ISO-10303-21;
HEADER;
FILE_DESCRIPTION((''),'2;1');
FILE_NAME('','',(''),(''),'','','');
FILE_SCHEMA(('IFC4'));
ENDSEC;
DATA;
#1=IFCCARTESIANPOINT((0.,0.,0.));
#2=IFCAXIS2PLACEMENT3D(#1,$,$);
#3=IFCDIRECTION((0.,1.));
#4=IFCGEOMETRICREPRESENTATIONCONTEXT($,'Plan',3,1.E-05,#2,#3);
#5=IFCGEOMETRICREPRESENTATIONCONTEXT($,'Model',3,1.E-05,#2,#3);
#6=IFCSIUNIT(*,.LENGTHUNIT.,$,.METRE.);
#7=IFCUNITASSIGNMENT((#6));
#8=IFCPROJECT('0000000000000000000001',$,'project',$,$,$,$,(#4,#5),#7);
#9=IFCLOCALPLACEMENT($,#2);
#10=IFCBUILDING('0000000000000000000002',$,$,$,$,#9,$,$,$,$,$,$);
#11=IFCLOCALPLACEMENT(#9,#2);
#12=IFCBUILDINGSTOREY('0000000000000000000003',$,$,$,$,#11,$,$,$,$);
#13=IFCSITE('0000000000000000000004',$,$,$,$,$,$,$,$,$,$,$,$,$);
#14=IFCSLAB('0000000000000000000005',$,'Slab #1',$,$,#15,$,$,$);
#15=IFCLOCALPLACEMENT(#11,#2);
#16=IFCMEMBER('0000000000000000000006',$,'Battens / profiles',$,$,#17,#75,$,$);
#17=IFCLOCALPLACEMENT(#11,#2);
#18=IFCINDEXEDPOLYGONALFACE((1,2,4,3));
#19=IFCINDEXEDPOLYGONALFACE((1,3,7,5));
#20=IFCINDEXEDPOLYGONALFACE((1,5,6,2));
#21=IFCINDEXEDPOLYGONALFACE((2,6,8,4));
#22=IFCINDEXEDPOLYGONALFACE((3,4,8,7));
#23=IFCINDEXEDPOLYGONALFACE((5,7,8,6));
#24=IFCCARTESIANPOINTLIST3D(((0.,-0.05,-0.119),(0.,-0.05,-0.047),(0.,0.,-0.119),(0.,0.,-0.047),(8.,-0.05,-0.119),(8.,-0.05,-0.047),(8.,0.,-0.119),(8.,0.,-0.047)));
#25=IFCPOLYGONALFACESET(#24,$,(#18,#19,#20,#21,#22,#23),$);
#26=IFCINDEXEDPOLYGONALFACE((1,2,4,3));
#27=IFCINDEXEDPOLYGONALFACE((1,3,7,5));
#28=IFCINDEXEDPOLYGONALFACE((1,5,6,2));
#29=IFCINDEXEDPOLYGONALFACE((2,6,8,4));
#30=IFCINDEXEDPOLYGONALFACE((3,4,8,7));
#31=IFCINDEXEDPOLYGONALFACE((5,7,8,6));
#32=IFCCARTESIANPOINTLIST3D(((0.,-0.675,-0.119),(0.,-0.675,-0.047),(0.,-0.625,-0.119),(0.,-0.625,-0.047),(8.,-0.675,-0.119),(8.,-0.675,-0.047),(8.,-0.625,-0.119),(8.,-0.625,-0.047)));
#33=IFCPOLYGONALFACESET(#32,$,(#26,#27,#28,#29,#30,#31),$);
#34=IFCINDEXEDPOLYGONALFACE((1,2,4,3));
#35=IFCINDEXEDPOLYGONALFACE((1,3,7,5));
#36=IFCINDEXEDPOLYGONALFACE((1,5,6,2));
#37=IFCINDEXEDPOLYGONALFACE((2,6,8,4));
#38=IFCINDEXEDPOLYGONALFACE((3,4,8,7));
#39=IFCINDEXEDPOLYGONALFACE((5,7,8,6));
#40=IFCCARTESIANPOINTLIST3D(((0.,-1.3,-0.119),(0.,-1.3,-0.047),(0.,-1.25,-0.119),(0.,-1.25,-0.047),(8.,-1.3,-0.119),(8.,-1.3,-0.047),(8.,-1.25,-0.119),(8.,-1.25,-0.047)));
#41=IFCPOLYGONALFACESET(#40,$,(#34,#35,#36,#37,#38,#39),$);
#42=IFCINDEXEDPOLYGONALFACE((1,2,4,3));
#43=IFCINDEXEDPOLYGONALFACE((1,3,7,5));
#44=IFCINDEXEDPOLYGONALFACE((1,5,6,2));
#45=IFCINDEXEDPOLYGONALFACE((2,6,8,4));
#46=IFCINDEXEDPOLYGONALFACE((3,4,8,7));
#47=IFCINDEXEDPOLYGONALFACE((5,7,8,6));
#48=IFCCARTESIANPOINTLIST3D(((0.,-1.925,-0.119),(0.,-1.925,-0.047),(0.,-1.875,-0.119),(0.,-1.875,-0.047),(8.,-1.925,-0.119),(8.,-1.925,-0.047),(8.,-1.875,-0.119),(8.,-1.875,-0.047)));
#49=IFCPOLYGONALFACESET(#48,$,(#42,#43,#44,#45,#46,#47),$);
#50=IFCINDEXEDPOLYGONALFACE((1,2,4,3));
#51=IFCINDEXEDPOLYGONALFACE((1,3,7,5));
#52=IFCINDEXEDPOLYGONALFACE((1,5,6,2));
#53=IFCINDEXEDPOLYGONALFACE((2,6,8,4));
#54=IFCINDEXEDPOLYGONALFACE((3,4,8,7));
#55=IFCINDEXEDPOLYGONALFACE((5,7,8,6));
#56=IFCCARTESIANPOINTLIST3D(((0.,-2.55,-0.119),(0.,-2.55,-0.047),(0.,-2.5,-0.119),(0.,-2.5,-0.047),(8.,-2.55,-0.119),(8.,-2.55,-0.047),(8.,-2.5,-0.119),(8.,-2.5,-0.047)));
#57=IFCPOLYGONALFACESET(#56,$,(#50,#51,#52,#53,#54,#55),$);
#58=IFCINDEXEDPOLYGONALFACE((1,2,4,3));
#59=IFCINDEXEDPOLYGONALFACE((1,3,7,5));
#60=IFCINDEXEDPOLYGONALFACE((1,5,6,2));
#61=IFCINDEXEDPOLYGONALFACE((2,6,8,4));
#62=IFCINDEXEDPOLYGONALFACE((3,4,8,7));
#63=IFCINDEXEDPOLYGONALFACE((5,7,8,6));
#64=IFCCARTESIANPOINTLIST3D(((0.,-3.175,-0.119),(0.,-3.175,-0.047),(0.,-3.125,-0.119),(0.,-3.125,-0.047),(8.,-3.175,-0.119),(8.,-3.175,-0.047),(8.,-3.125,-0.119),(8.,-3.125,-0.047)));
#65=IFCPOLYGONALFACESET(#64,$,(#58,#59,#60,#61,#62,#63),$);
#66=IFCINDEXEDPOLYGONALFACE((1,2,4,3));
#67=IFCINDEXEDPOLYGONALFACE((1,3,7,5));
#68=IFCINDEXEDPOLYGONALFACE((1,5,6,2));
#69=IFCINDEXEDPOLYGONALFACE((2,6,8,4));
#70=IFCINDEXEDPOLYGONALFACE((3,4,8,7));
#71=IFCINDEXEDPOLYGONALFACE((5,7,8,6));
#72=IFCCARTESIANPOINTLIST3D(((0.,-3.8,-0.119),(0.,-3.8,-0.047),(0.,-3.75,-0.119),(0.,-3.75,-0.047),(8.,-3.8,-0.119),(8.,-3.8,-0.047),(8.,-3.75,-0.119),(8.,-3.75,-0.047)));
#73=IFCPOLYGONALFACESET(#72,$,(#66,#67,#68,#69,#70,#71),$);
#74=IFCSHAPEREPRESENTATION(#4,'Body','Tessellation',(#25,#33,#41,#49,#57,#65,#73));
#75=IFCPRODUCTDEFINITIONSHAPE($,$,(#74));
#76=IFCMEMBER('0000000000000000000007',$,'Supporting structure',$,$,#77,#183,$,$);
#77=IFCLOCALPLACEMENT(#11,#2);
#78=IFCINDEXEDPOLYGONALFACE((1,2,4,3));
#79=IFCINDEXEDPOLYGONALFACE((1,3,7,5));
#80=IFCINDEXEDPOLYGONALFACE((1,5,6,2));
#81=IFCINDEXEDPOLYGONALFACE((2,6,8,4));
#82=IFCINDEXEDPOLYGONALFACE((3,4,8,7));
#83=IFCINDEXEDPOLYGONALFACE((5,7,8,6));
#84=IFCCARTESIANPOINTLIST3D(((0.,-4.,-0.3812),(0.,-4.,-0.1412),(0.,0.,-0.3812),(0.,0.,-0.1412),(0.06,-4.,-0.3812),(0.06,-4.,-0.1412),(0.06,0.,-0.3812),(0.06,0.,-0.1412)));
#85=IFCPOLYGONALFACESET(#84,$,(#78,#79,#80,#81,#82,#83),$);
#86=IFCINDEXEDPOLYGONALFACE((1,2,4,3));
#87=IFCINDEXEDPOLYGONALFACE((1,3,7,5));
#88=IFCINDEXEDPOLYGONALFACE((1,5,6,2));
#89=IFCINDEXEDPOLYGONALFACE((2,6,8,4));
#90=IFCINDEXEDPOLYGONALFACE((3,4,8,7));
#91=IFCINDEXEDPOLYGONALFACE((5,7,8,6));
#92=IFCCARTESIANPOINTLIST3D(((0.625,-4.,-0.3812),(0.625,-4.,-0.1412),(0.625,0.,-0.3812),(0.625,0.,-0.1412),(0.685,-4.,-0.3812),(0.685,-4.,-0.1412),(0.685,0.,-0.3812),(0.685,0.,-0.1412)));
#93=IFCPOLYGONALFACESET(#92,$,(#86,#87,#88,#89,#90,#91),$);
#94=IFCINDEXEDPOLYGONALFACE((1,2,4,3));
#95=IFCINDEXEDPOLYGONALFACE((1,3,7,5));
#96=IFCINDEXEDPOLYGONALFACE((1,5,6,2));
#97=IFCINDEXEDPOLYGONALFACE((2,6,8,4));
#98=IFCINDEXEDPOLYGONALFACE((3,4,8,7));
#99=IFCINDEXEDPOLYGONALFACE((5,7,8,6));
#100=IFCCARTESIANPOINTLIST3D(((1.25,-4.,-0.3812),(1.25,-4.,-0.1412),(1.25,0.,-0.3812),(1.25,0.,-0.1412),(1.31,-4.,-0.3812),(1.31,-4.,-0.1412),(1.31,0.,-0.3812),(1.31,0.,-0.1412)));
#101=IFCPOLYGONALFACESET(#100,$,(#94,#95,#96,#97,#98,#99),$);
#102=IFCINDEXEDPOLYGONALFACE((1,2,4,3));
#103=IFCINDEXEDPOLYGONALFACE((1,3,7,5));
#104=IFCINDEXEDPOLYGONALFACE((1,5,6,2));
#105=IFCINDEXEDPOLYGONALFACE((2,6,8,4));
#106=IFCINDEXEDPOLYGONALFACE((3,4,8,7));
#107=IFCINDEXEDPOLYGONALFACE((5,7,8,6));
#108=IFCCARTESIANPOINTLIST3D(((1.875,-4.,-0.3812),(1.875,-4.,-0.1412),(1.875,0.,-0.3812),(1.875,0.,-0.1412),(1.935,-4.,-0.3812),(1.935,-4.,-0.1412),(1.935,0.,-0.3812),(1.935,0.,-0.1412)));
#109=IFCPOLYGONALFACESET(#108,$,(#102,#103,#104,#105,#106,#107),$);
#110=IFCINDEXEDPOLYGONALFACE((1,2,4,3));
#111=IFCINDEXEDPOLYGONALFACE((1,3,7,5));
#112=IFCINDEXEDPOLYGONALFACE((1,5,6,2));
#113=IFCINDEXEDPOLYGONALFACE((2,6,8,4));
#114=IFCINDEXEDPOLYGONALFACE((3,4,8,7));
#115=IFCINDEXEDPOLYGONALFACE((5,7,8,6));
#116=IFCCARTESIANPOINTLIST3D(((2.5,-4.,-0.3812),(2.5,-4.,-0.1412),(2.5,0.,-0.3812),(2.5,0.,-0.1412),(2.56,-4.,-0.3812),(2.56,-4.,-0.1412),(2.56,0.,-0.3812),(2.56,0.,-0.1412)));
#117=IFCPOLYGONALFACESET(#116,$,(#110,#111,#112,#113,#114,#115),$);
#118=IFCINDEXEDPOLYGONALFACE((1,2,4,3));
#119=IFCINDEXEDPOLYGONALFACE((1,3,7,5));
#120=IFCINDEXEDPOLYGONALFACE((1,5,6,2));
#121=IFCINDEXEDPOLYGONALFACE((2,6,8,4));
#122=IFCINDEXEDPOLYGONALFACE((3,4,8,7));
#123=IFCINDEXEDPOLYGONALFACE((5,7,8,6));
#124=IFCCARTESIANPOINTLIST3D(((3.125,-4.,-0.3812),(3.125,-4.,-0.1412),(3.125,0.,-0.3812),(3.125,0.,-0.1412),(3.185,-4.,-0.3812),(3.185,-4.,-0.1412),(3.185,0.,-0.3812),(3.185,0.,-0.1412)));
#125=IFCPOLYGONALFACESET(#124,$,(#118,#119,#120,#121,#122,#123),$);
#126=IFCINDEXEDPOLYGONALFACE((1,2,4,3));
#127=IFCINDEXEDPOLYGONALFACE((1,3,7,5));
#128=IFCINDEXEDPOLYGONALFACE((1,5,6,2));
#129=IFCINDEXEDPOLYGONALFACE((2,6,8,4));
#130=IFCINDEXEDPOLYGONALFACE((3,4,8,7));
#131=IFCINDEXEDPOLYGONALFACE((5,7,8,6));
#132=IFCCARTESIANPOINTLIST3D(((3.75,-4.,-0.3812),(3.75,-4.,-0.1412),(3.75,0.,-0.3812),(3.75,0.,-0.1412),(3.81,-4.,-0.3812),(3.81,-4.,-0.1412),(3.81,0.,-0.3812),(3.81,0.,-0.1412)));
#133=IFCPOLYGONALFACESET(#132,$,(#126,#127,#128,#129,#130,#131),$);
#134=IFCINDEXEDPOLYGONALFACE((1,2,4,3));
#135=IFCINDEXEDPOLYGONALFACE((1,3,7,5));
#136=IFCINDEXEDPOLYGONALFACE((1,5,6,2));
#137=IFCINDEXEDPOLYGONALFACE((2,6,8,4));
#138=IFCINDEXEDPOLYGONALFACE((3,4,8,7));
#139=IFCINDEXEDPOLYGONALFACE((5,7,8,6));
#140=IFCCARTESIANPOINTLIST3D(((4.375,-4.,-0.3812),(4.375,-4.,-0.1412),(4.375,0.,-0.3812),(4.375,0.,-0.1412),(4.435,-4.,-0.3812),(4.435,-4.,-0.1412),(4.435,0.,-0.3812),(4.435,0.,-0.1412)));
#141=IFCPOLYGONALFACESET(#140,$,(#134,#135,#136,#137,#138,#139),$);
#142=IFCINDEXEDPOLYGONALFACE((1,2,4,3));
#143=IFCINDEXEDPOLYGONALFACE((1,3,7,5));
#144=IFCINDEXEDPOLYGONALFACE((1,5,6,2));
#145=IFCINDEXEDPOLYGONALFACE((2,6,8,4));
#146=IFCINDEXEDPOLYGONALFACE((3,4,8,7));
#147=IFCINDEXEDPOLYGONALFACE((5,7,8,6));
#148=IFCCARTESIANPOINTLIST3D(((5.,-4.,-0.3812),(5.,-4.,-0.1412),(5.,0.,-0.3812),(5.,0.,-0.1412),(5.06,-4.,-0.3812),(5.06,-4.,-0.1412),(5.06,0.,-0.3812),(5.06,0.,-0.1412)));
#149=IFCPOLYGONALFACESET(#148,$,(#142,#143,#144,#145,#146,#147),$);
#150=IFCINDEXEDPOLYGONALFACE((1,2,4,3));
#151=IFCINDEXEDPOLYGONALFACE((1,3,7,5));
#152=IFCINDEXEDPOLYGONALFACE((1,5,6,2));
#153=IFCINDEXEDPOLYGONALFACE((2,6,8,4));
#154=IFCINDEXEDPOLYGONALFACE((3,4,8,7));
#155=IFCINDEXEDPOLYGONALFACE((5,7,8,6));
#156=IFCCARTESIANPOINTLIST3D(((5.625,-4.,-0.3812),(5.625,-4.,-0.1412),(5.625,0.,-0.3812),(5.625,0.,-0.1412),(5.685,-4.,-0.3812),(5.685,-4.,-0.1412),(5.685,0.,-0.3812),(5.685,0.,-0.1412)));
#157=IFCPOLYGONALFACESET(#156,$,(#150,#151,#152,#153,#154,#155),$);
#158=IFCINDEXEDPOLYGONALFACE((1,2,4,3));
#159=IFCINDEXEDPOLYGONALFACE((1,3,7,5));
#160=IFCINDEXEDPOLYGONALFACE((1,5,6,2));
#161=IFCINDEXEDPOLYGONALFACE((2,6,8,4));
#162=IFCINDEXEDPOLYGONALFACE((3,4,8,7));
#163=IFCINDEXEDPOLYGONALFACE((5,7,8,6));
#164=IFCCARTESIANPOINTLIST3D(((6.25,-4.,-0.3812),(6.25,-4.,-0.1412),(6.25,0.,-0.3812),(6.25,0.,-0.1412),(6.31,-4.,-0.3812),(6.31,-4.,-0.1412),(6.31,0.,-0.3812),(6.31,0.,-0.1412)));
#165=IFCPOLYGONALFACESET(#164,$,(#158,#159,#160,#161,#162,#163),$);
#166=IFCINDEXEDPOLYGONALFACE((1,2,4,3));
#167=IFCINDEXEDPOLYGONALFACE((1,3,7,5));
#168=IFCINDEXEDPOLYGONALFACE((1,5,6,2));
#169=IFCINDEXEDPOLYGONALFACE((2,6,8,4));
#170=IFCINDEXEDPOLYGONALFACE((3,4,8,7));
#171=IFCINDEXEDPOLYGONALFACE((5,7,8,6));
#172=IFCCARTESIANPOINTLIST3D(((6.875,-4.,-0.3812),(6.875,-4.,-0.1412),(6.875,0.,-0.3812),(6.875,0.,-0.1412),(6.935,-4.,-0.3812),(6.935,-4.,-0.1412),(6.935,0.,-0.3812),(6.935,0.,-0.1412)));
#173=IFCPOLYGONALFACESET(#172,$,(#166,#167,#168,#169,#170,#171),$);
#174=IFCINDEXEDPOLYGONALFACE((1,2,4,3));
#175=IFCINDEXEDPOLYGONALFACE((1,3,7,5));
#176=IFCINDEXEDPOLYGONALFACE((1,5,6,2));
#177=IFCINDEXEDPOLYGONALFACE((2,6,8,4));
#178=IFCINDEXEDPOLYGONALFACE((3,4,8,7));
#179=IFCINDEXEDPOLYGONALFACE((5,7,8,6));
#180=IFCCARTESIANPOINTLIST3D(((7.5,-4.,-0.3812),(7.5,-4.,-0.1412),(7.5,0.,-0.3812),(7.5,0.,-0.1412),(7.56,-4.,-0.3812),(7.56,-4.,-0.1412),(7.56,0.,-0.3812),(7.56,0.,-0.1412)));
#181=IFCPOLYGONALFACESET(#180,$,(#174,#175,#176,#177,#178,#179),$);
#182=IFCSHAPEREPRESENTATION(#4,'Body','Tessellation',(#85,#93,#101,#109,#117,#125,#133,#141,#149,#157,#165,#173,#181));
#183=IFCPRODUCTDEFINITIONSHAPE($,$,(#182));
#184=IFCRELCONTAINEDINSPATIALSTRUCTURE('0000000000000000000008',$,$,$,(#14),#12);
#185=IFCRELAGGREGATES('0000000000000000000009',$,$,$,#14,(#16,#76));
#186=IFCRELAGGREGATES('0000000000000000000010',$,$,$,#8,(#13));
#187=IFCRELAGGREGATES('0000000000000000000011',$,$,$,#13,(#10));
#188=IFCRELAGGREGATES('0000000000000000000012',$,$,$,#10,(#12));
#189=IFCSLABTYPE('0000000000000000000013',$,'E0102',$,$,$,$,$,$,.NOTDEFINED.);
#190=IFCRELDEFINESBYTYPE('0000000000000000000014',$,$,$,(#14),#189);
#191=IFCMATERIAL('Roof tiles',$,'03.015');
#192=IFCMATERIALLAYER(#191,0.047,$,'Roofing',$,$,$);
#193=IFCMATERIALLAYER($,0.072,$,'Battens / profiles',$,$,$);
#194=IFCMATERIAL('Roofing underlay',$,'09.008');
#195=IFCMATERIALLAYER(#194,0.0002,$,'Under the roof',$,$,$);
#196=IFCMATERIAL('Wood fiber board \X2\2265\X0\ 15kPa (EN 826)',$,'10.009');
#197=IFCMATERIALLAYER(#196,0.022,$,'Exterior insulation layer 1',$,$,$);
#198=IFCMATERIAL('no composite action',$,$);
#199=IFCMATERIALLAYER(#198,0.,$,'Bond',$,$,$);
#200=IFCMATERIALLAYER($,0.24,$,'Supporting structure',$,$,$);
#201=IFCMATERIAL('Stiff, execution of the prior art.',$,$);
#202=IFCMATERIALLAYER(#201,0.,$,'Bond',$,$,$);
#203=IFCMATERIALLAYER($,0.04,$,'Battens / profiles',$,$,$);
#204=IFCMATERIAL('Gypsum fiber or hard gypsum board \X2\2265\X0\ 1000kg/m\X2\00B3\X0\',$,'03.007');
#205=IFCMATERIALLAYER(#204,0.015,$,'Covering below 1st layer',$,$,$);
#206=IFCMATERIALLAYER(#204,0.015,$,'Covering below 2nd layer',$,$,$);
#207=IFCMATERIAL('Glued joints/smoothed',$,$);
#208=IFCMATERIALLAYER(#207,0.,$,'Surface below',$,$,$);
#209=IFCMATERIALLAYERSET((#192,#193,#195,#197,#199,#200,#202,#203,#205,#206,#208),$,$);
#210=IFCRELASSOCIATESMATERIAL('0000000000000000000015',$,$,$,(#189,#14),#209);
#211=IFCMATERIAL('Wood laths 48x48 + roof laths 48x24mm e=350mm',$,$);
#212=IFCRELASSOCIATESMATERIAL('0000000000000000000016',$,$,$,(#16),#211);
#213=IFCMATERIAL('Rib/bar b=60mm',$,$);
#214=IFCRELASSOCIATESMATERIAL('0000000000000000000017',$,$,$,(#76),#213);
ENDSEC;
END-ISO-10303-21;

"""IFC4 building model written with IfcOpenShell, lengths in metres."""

from ifc_helpers import new_model, si_unit, direction, frame, frame_2d, origin, place, context, project, spatial, rectangle, extrude, material, layer, layer_set, type_object, element, aggregate, save


model = new_model("IFC4")

# Units and contexts
plan_context = context("Plan", 3, precision=1e-05, world=origin(), true_north=direction((0.0, 1.0)))
model_context = context("Model", 3, precision=1e-05, world=origin(), true_north=direction((0.0, 1.0)))
ifc_project = project(units=[si_unit("LENGTHUNIT", "METRE")], contexts=[plan_context, model_context])

# Site, building, storey
site = spatial("IfcSite", under=ifc_project)
building_placement = place(None, origin())
building = spatial("IfcBuilding", under=site, at=building_placement)
storey_placement = place(building_placement, origin())
storey = spatial("IfcBuildingStorey", under=building, at=storey_placement)

# Slab, members
ifc_material_1 = material(Name="Roof tiles", Category="03.015")
ifc_layer_1 = layer(ifc_material_1, 0.047, Name="Roofing")
ifc_layer_2 = layer(None, 0.072, Name="Battens / profiles")
ifc_material_2 = material(Name="Roofing underlay", Category="09.008")
ifc_layer_3 = layer(ifc_material_2, 0.0002, Name="Under the roof")
ifc_material_3 = material(Name="Wood fiber board ≥ 15kPa (EN 826)", Category="10.009")
ifc_layer_4 = layer(ifc_material_3, 0.022, Name="Exterior insulation layer 1")
ifc_material_4 = material(Name="no composite action")
ifc_layer_5 = layer(ifc_material_4, 0.0, Name="Bond")
ifc_layer_6 = layer(None, 0.24, Name="Supporting structure")
ifc_material_5 = material(Name="Stiff, execution of the prior art.")
ifc_layer_7 = layer(ifc_material_5, 0.0, Name="Bond")
ifc_layer_8 = layer(None, 0.04, Name="Battens / profiles")
ifc_material_6 = material(Name="Gypsum fiber or hard gypsum board ≥ 1000kg/m³", Category="03.007")
ifc_layer_9 = layer(ifc_material_6, 0.015, Name="Covering below 1st layer")
ifc_layer_10 = layer(ifc_material_6, 0.015, Name="Covering below 2nd layer")
ifc_material_7 = material(Name="Glued joints/smoothed")
ifc_layer_11 = layer(ifc_material_7, 0.0, Name="Surface below")
ifc_layer_set = layer_set([ifc_layer_1, ifc_layer_2, ifc_layer_3, ifc_layer_4, ifc_layer_5, ifc_layer_6, ifc_layer_7, ifc_layer_8, ifc_layer_9, ifc_layer_10, ifc_layer_11])
slab_type = type_object("IfcSlabType", Name="E0102", PredefinedType="NOTDEFINED", material=ifc_layer_set)
slab_placement = place(None, frame((0.0, 0.0, 0.0), z_axis=(0.0, 0.0, -1.0), x_axis=(1.0, 0.0, 0.0)))
slab = element("IfcSlab", 1, at=slab_placement, inside=storey, type_object=slab_type, material=ifc_layer_set, Name="Slab #1")
ifc_material_8 = material(Name="Wood laths 48x48 + roof laths 48x24mm e=350mm")
member_1_placement = place(slab_placement, origin())
member_1 = element("IfcMember", 2, at=member_1_placement, material=ifc_material_8, Name="Battens / profiles", context=plan_context, shape_type="SweptSolid", body=[
    extrude(rectangle(XDim=0.05, YDim=0.072, at=frame_2d((0.025, 0.036), x_axis=(1.0, 0.0))), frame((0.0, 0.0, 0.047), z_axis=(1.0, 0.0, 0.0), x_axis=(0.0, 1.0, 0.0)), (0.0, 0.0, 1.0), 8.0),
    extrude(rectangle(XDim=0.05, YDim=0.072, at=frame_2d((0.025, 0.036), x_axis=(1.0, 0.0))), frame((0.0, 0.625, 0.047), z_axis=(1.0, 0.0, 0.0), x_axis=(0.0, 1.0, 0.0)), (0.0, 0.0, 1.0), 8.0),
    extrude(rectangle(XDim=0.05, YDim=0.072, at=frame_2d((0.025, 0.036), x_axis=(1.0, 0.0))), frame((0.0, 1.25, 0.047), z_axis=(1.0, 0.0, 0.0), x_axis=(0.0, 1.0, 0.0)), (0.0, 0.0, 1.0), 8.0),
    extrude(rectangle(XDim=0.05, YDim=0.072, at=frame_2d((0.025, 0.036), x_axis=(1.0, 0.0))), frame((0.0, 1.875, 0.047), z_axis=(1.0, 0.0, 0.0), x_axis=(0.0, 1.0, 0.0)), (0.0, 0.0, 1.0), 8.0),
    extrude(rectangle(XDim=0.05, YDim=0.072, at=frame_2d((0.025, 0.036), x_axis=(1.0, 0.0))), frame((0.0, 2.5, 0.047), z_axis=(1.0, 0.0, 0.0), x_axis=(0.0, 1.0, 0.0)), (0.0, 0.0, 1.0), 8.0),
    extrude(rectangle(XDim=0.05, YDim=0.072, at=frame_2d((0.025, 0.036), x_axis=(1.0, 0.0))), frame((0.0, 3.125, 0.047), z_axis=(1.0, 0.0, 0.0), x_axis=(0.0, 1.0, 0.0)), (0.0, 0.0, 1.0), 8.0),
    extrude(rectangle(XDim=0.05, YDim=0.072, at=frame_2d((0.025, 0.036), x_axis=(1.0, 0.0))), frame((0.0, 3.75, 0.047), z_axis=(1.0, 0.0, 0.0), x_axis=(0.0, 1.0, 0.0)), (0.0, 0.0, 1.0), 8.0),
])
ifc_material_9 = material(Name="Rib/bar b=60mm")
member_2_placement = place(slab_placement, origin())
member_2 = element("IfcMember", 3, at=member_2_placement, material=ifc_material_9, Name="Supporting structure", context=plan_context, shape_type="SweptSolid", body=[
    extrude(rectangle(XDim=0.06, YDim=0.24, at=frame_2d((0.03, 0.12), x_axis=(1.0, 0.0))), frame((0.0, 4.0, 0.1412), z_axis=(0.0, -1.0, 0.0), x_axis=(1.0, 0.0, 0.0)), (0.0, 0.0, 1.0), 4.0),
    extrude(rectangle(XDim=0.06, YDim=0.24, at=frame_2d((0.03, 0.12), x_axis=(1.0, 0.0))), frame((0.625, 4.0, 0.1412), z_axis=(0.0, -1.0, 0.0), x_axis=(1.0, 0.0, 0.0)), (0.0, 0.0, 1.0), 4.0),
    extrude(rectangle(XDim=0.06, YDim=0.24, at=frame_2d((0.03, 0.12), x_axis=(1.0, 0.0))), frame((1.25, 4.0, 0.1412), z_axis=(0.0, -1.0, 0.0), x_axis=(1.0, 0.0, 0.0)), (0.0, 0.0, 1.0), 4.0),
    extrude(rectangle(XDim=0.06, YDim=0.24, at=frame_2d((0.03, 0.12), x_axis=(1.0, 0.0))), frame((1.875, 4.0, 0.1412), z_axis=(0.0, -1.0, 0.0), x_axis=(1.0, 0.0, 0.0)), (0.0, 0.0, 1.0), 4.0),
    extrude(rectangle(XDim=0.06, YDim=0.24, at=frame_2d((0.03, 0.12), x_axis=(1.0, 0.0))), frame((2.5, 4.0, 0.1412), z_axis=(0.0, -1.0, 0.0), x_axis=(1.0, 0.0, 0.0)), (0.0, 0.0, 1.0), 4.0),
    extrude(rectangle(XDim=0.06, YDim=0.24, at=frame_2d((0.03, 0.12), x_axis=(1.0, 0.0))), frame((3.125, 4.0, 0.1412), z_axis=(0.0, -1.0, 0.0), x_axis=(1.0, 0.0, 0.0)), (0.0, 0.0, 1.0), 4.0),
    extrude(rectangle(XDim=0.06, YDim=0.24, at=frame_2d((0.03, 0.12), x_axis=(1.0, 0.0))), frame((3.75, 4.0, 0.1412), z_axis=(0.0, -1.0, 0.0), x_axis=(1.0, 0.0, 0.0)), (0.0, 0.0, 1.0), 4.0),
    extrude(rectangle(XDim=0.06, YDim=0.24, at=frame_2d((0.03, 0.12), x_axis=(1.0, 0.0))), frame((4.375, 4.0, 0.1412), z_axis=(0.0, -1.0, 0.0), x_axis=(1.0, 0.0, 0.0)), (0.0, 0.0, 1.0), 4.0),
    extrude(rectangle(XDim=0.06, YDim=0.24, at=frame_2d((0.03, 0.12), x_axis=(1.0, 0.0))), frame((5.0, 4.0, 0.1412), z_axis=(0.0, -1.0, 0.0), x_axis=(1.0, 0.0, 0.0)), (0.0, 0.0, 1.0), 4.0),
    extrude(rectangle(XDim=0.06, YDim=0.24, at=frame_2d((0.03, 0.12), x_axis=(1.0, 0.0))), frame((5.625, 4.0, 0.1412), z_axis=(0.0, -1.0, 0.0), x_axis=(1.0, 0.0, 0.0)), (0.0, 0.0, 1.0), 4.0),
    extrude(rectangle(XDim=0.06, YDim=0.24, at=frame_2d((0.03, 0.12), x_axis=(1.0, 0.0))), frame((6.25, 4.0, 0.1412), z_axis=(0.0, -1.0, 0.0), x_axis=(1.0, 0.0, 0.0)), (0.0, 0.0, 1.0), 4.0),
    extrude(rectangle(XDim=0.06, YDim=0.24, at=frame_2d((0.03, 0.12), x_axis=(1.0, 0.0))), frame((6.875, 4.0, 0.1412), z_axis=(0.0, -1.0, 0.0), x_axis=(1.0, 0.0, 0.0)), (0.0, 0.0, 1.0), 4.0),
    extrude(rectangle(XDim=0.06, YDim=0.24, at=frame_2d((0.03, 0.12), x_axis=(1.0, 0.0))), frame((7.5, 4.0, 0.1412), z_axis=(0.0, -1.0, 0.0), x_axis=(1.0, 0.0, 0.0)), (0.0, 0.0, 1.0), 4.0),
])
aggregate(slab, [member_1, member_2])

save(model, "model.ifc")
